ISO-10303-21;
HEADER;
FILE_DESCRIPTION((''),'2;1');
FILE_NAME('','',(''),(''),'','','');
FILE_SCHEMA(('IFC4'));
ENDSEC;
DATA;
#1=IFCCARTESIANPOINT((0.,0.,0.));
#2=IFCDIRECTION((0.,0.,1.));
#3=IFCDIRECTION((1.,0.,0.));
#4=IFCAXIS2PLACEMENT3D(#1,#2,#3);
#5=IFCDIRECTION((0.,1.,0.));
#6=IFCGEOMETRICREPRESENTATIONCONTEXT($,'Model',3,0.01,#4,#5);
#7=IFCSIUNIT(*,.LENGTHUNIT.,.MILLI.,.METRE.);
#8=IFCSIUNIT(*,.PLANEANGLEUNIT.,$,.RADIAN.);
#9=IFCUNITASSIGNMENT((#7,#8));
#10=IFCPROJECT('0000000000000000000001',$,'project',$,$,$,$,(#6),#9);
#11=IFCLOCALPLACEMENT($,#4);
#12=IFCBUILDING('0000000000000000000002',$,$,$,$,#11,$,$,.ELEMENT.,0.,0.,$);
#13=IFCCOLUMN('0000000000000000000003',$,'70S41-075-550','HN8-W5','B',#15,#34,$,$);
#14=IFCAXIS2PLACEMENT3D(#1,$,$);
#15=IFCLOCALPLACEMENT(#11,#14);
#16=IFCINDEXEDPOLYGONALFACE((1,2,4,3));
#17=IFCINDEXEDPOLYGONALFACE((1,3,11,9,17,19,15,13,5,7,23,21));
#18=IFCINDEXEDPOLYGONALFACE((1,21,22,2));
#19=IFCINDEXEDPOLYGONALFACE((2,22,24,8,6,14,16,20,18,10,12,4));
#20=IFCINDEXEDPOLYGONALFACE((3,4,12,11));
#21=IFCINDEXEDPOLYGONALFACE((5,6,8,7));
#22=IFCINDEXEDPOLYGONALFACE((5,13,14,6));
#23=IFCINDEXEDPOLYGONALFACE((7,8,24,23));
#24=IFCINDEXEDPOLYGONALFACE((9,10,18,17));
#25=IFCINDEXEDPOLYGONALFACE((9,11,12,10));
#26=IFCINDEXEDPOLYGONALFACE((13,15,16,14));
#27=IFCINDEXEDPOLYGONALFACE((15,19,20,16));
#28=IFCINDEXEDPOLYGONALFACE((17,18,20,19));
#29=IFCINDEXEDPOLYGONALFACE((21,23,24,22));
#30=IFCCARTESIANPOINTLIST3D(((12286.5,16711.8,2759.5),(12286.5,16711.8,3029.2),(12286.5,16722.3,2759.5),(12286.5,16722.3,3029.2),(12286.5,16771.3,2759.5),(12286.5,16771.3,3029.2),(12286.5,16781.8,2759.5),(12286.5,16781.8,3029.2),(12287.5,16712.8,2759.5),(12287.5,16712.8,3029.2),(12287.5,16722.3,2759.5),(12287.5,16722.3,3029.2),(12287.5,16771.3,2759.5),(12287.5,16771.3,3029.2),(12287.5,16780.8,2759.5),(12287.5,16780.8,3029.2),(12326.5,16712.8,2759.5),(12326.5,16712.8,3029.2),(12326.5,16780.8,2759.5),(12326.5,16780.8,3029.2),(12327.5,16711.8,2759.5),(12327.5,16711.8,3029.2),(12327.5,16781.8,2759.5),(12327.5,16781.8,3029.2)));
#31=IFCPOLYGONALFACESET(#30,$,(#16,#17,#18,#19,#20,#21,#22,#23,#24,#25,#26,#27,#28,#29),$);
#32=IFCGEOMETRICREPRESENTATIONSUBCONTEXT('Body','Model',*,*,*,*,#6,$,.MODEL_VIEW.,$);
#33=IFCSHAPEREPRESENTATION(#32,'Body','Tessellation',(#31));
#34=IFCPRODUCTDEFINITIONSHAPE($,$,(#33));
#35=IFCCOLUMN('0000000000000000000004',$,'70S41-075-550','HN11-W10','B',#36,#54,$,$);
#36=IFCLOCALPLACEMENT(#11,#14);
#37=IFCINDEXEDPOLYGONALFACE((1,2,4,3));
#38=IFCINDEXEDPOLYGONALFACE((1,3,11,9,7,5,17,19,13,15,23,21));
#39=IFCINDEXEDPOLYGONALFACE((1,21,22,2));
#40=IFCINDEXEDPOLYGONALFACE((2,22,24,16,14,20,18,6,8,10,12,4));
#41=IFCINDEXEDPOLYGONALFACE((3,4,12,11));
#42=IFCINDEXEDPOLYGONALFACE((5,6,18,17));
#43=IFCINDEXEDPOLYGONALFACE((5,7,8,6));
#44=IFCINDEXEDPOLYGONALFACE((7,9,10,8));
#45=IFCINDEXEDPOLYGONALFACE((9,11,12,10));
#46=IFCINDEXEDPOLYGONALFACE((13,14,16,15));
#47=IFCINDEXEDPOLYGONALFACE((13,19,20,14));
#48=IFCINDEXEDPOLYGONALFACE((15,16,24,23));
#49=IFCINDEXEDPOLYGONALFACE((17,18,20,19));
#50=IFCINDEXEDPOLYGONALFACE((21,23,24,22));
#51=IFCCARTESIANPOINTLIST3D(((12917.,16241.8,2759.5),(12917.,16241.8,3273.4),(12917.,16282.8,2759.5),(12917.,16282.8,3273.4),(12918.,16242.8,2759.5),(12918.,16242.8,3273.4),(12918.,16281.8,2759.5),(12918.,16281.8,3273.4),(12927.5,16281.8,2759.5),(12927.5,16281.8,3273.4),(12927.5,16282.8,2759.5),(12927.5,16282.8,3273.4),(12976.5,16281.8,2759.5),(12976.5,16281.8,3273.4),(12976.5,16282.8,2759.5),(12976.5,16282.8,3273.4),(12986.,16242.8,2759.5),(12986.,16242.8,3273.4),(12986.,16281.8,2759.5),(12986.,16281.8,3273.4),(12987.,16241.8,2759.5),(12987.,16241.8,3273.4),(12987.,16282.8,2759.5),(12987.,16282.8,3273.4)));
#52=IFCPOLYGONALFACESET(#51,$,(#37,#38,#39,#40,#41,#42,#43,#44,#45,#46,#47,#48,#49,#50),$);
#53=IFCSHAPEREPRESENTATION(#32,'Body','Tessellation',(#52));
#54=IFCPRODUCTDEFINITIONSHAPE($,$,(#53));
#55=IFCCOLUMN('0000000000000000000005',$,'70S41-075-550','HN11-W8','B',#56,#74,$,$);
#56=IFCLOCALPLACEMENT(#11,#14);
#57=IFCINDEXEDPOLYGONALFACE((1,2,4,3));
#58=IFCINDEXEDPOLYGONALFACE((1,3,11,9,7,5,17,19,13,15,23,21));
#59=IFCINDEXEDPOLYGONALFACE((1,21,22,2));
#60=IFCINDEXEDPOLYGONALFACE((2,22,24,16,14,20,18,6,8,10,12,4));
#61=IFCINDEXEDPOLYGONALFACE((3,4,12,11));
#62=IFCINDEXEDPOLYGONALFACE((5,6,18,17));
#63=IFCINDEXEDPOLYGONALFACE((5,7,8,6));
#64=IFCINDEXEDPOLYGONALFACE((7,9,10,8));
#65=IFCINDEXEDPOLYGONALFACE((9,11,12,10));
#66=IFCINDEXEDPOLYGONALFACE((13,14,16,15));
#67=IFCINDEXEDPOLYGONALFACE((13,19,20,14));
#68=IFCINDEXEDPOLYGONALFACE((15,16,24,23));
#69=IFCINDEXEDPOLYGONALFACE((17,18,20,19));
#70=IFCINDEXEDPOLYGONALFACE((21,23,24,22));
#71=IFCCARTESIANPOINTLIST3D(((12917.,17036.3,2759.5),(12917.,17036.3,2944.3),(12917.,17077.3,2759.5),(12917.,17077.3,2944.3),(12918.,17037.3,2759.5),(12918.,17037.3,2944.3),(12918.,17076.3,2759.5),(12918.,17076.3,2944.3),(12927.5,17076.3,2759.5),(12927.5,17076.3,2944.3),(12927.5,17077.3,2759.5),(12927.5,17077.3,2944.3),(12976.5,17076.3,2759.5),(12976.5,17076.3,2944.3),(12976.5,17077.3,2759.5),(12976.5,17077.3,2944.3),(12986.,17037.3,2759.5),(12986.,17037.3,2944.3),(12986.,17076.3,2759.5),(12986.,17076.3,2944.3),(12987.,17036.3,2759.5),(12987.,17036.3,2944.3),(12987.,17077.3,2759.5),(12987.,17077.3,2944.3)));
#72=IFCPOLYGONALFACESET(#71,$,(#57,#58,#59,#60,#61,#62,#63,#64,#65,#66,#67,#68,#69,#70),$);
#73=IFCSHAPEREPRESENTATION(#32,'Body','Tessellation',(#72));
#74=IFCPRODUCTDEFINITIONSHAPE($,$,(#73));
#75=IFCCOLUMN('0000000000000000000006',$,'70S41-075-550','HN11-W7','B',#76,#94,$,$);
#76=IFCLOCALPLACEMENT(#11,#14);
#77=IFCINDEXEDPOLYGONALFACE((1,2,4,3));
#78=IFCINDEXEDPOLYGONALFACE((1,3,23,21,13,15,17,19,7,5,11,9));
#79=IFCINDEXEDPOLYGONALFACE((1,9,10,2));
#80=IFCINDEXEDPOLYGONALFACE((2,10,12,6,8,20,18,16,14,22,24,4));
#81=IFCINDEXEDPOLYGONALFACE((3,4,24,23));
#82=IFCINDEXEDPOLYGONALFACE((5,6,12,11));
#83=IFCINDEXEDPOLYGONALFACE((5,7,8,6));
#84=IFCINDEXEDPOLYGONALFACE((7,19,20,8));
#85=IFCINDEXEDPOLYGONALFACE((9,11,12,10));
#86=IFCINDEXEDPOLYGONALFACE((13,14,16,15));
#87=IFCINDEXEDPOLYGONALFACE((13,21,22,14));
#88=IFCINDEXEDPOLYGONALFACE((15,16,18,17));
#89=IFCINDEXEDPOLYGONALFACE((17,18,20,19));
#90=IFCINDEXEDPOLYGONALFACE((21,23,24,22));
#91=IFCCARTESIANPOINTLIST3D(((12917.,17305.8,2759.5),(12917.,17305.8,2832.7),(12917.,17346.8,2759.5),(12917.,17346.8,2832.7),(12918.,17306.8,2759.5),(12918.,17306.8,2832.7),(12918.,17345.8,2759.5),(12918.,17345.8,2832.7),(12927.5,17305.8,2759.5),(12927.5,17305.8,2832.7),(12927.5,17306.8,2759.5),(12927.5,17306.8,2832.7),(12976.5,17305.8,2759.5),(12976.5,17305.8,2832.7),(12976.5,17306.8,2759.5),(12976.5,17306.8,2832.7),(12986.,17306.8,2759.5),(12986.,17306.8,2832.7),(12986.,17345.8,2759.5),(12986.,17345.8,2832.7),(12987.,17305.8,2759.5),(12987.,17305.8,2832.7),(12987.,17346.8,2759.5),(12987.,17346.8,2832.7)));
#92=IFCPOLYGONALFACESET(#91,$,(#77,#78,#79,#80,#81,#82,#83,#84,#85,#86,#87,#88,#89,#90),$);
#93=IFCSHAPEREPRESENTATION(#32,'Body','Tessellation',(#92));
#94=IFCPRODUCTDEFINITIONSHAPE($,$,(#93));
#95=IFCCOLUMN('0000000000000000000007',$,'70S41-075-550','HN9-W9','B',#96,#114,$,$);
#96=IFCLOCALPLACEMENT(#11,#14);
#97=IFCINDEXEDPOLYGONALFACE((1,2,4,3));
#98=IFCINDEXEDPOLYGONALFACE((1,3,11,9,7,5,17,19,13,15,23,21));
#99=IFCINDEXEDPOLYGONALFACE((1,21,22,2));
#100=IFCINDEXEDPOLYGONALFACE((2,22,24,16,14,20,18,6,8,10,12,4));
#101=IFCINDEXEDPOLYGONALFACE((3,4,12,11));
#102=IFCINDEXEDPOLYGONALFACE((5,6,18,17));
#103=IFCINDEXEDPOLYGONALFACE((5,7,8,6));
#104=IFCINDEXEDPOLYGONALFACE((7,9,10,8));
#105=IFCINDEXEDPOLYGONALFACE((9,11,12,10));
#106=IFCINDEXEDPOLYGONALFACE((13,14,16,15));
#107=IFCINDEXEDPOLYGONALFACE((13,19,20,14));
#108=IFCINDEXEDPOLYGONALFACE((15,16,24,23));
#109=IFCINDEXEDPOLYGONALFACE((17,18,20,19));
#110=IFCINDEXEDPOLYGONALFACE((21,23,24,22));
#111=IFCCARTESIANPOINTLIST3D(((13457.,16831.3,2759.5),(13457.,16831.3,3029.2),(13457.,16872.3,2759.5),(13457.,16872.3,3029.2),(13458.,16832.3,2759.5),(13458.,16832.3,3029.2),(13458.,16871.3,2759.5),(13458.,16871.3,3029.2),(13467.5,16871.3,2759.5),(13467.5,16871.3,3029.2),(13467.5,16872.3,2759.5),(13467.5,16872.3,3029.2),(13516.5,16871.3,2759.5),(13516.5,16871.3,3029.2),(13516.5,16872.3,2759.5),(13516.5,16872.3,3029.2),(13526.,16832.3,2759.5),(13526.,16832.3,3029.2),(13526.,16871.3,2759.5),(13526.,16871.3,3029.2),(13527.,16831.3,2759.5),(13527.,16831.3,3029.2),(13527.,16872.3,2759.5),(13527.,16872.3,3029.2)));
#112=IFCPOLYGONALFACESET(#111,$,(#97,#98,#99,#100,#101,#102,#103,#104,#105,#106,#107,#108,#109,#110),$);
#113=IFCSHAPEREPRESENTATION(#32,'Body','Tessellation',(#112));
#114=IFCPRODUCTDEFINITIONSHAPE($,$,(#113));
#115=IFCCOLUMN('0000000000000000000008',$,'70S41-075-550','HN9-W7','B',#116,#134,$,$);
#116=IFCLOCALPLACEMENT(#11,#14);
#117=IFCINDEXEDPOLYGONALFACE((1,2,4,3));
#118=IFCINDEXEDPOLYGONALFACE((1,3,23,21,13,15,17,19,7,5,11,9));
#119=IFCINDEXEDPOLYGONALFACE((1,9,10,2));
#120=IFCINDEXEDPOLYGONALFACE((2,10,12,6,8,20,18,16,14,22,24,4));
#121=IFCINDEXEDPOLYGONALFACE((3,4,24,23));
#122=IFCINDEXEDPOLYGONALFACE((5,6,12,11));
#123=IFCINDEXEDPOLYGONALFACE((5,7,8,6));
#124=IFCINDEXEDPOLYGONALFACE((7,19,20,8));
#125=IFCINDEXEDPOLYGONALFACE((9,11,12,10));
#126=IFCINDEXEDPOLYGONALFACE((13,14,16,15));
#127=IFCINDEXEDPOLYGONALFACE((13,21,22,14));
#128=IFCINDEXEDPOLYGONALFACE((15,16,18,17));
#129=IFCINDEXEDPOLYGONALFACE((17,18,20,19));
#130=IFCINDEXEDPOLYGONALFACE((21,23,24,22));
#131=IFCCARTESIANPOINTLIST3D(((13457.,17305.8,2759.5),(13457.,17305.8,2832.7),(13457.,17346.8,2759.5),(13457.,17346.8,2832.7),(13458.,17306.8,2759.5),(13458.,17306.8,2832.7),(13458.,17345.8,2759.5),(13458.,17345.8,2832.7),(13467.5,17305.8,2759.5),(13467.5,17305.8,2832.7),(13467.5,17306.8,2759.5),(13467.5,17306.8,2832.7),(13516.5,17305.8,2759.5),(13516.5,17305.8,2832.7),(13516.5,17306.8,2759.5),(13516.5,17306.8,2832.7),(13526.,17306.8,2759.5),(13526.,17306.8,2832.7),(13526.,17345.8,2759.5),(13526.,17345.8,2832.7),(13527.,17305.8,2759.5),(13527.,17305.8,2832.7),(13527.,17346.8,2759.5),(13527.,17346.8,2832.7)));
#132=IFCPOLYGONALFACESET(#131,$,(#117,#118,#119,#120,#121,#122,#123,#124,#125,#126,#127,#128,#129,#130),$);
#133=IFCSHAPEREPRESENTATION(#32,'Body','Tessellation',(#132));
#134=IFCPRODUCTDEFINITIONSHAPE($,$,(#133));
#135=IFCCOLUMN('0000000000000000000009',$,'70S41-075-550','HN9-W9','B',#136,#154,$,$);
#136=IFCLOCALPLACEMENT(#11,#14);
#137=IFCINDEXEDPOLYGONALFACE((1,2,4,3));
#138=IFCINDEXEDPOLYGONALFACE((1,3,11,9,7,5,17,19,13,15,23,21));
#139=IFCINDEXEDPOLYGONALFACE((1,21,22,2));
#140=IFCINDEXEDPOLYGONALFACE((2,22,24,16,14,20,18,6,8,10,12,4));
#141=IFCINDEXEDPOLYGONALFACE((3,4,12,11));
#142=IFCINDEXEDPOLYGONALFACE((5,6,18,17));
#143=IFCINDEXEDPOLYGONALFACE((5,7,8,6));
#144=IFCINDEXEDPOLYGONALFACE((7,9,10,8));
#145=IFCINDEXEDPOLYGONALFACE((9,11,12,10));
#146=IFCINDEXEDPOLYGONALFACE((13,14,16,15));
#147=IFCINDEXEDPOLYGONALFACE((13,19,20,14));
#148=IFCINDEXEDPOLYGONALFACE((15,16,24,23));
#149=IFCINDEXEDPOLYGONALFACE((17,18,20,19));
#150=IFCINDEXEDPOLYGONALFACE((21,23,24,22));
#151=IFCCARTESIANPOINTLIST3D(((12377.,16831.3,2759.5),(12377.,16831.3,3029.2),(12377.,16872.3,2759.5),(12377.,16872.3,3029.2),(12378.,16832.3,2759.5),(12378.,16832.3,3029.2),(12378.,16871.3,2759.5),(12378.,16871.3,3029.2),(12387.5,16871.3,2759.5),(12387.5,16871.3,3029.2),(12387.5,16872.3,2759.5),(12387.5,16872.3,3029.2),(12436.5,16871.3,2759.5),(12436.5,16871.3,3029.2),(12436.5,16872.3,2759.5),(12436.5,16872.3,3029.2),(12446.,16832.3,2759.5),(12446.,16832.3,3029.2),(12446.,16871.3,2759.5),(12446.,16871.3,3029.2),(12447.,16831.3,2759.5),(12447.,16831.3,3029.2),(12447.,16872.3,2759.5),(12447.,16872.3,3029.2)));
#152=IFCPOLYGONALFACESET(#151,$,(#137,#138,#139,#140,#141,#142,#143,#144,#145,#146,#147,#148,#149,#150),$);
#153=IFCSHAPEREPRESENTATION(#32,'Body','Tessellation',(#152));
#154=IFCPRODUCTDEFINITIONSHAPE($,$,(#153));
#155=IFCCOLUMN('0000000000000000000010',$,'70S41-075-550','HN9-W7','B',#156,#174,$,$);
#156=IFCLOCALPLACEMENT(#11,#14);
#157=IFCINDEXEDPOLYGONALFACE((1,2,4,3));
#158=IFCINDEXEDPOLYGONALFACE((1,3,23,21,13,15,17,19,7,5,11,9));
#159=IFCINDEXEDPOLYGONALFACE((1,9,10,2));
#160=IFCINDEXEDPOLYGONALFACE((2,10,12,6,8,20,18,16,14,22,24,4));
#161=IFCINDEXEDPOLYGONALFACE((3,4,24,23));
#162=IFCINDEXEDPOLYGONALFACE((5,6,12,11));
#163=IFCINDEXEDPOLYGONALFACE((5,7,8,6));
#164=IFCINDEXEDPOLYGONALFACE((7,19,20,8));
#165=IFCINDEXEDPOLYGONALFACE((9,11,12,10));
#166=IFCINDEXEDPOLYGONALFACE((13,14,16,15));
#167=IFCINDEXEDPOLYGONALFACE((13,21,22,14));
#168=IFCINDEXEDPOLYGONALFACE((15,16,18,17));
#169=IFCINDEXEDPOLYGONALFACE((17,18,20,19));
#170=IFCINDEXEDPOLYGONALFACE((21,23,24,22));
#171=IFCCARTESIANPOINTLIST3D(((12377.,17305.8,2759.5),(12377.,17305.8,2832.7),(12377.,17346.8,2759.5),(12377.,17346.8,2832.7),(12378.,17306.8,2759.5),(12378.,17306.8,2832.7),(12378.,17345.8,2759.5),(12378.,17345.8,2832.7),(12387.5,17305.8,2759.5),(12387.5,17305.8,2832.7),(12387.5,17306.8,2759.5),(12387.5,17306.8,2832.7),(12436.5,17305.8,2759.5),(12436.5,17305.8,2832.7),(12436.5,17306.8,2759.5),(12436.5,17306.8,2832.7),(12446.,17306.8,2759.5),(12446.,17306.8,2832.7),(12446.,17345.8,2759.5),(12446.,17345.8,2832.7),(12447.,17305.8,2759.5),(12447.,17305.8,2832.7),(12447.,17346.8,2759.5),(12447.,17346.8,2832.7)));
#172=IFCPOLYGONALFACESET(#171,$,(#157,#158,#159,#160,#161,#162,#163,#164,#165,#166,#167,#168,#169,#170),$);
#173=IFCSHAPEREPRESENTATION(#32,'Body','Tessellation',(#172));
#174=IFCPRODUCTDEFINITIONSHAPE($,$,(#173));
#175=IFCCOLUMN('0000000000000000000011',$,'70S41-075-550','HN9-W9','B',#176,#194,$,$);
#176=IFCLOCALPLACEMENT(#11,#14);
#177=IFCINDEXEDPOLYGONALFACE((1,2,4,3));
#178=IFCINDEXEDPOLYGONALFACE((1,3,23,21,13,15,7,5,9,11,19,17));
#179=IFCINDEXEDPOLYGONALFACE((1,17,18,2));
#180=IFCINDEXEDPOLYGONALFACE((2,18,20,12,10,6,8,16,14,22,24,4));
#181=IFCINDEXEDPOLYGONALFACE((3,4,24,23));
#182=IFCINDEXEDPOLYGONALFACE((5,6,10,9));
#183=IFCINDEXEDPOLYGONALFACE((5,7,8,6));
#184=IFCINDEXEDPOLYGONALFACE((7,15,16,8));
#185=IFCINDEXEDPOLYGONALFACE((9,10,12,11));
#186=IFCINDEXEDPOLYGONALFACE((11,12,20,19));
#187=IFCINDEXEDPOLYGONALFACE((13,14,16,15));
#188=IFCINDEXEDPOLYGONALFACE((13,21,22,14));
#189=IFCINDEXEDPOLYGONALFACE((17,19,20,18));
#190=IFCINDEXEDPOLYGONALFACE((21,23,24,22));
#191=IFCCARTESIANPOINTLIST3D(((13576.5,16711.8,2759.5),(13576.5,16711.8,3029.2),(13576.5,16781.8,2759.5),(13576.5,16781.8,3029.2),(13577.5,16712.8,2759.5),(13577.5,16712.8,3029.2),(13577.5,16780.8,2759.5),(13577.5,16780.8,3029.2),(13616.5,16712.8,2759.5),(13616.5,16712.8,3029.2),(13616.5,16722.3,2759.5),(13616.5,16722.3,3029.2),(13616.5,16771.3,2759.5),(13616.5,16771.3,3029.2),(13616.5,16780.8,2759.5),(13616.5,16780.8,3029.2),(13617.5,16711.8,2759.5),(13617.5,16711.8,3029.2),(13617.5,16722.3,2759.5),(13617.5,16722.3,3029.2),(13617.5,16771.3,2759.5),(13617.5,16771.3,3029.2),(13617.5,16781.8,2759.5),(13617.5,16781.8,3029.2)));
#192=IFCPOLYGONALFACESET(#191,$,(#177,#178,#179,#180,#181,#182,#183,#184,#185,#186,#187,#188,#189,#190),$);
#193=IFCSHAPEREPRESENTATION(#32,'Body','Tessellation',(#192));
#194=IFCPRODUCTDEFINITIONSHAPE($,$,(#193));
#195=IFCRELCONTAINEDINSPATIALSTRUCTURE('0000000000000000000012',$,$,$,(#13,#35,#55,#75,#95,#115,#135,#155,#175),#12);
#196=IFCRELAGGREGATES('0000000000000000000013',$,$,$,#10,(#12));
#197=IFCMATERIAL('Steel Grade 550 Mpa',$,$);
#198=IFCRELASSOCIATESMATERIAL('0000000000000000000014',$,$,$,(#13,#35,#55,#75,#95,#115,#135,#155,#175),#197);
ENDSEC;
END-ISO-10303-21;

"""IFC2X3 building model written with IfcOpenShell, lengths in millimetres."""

from ifc_helpers import new_model, si_unit, direction, frame, origin, origin_with_axes, origin_2d_with_axis, place, context, subcontext, project, spatial, c_section, extrude, source, transform, mapped, material, element, save


model = new_model("IFC2X3")

# Units and contexts
model_context = context("Model", 3, precision=0.01, world=origin_with_axes(), true_north=direction((0.0, 1.0, 0.0)))
body_context = subcontext(model_context, "Body", "Model", "MODEL_VIEW")
ifc_project = project(units=[si_unit("LENGTHUNIT", "METRE", prefix="MILLI"), si_unit("PLANEANGLEUNIT", "RADIAN")], contexts=[model_context])

# Building
building_placement = place(None, origin_with_axes())
building = spatial("IfcBuilding", under=ifc_project, at=building_placement, CompositionType="ELEMENT", ElevationOfRefHeight=0.0, ElevationOfTerrain=0.0)

# Columns
ifc_material = material(Name="Steel Grade 550 Mpa")
shared_shape_1 = source(origin(), body_context, "Body", "SweptSolid", [
    extrude(c_section(Depth=70.0, Width=41.0, WallThickness=1.0, Girth=10.5, at=origin_2d_with_axis()), origin_with_axes(), (0.0, 0.0, 1.0), 269.7),
])
column_1_placement = place(None, frame((12307.0, 16746.8, 2759.5), z_axis=(0.0, 0.0, 1.0), x_axis=(-1.0, 0.0, 0.0)))
element("IfcColumn", 1, at=column_1_placement, inside=building, material=ifc_material, Name="70S41-075-550", Description="HN8-W5", ObjectType="B", context=body_context, shape_type="MappedRepresentation", body=[
    mapped(shared_shape_1, transform((0.0, 0.0, 0.0), scale=1.0)),
])
shared_shape_2 = source(origin(), body_context, "Body", "SweptSolid", [
    extrude(c_section(Depth=70.0, Width=41.0, WallThickness=1.0, Girth=10.5, at=origin_2d_with_axis()), origin_with_axes(), (0.0, 0.0, 1.0), 513.9),
])
column_2_placement = place(None, frame((12952.0, 16262.3, 2759.5), z_axis=(0.0, 0.0, 1.0), x_axis=(0.0, 1.0, 0.0)))
element("IfcColumn", 2, at=column_2_placement, inside=building, material=ifc_material, Name="70S41-075-550", Description="HN11-W10", ObjectType="B", context=body_context, shape_type="MappedRepresentation", body=[
    mapped(shared_shape_2, transform((0.0, 0.0, 0.0), scale=1.0)),
])
shared_shape_3 = source(origin(), body_context, "Body", "SweptSolid", [
    extrude(c_section(Depth=70.0, Width=41.0, WallThickness=1.0, Girth=10.5, at=origin_2d_with_axis()), origin_with_axes(), (0.0, 0.0, 1.0), 184.8),
])
column_3_placement = place(None, frame((12952.0, 17056.8, 2759.5), z_axis=(0.0, 0.0, 1.0), x_axis=(0.0, 1.0, 0.0)))
element("IfcColumn", 3, at=column_3_placement, inside=building, material=ifc_material, Name="70S41-075-550", Description="HN11-W8", ObjectType="B", context=body_context, shape_type="MappedRepresentation", body=[
    mapped(shared_shape_3, transform((0.0, 0.0, 0.0), scale=1.0)),
])
shared_shape_4 = source(origin(), body_context, "Body", "SweptSolid", [
    extrude(c_section(Depth=70.0, Width=41.0, WallThickness=1.0, Girth=10.5, at=origin_2d_with_axis()), origin_with_axes(), (0.0, 0.0, 1.0), 73.2),
])
column_4_placement = place(None, frame((12952.0, 17326.3, 2832.7), z_axis=(0.0, 0.0, -1.0), x_axis=(0.0, -1.0, 0.0)))
element("IfcColumn", 4, at=column_4_placement, inside=building, material=ifc_material, Name="70S41-075-550", Description="HN11-W7", ObjectType="B", context=body_context, shape_type="MappedRepresentation", body=[
    mapped(shared_shape_4, transform((0.0, 0.0, 0.0), scale=1.0)),
])
shared_shape_5 = source(origin(), body_context, "Body", "SweptSolid", [
    extrude(c_section(Depth=70.0, Width=41.0, WallThickness=1.0, Girth=10.5, at=origin_2d_with_axis()), origin_with_axes(), (0.0, 0.0, 1.0), 269.7),
])
column_5_placement = place(None, frame((13492.0, 16851.8, 2759.5), z_axis=(0.0, 0.0, 1.0), x_axis=(0.0, 1.0, 0.0)))
element("IfcColumn", 5, at=column_5_placement, inside=building, material=ifc_material, Name="70S41-075-550", Description="HN9-W9", ObjectType="B", context=body_context, shape_type="MappedRepresentation", body=[
    mapped(shared_shape_5, transform((0.0, 0.0, 0.0), scale=1.0)),
])
shared_shape_6 = source(origin(), body_context, "Body", "SweptSolid", [
    extrude(c_section(Depth=70.0, Width=41.0, WallThickness=1.0, Girth=10.5, at=origin_2d_with_axis()), origin_with_axes(), (0.0, 0.0, 1.0), 73.2),
])
column_6_placement = place(None, frame((13492.0, 17326.3, 2832.7), z_axis=(0.0, 0.0, -1.0), x_axis=(0.0, -1.0, 0.0)))
element("IfcColumn", 6, at=column_6_placement, inside=building, material=ifc_material, Name="70S41-075-550", Description="HN9-W7", ObjectType="B", context=body_context, shape_type="MappedRepresentation", body=[
    mapped(shared_shape_6, transform((0.0, 0.0, 0.0), scale=1.0)),
])
shared_shape_7 = source(origin(), body_context, "Body", "SweptSolid", [
    extrude(c_section(Depth=70.0, Width=41.0, WallThickness=1.0, Girth=10.5, at=origin_2d_with_axis()), origin_with_axes(), (0.0, 0.0, 1.0), 269.7),
])
column_7_placement = place(None, frame((12412.0, 16851.8, 2759.5), z_axis=(0.0, 0.0, 1.0), x_axis=(0.0, 1.0, 0.0)))
element("IfcColumn", 7, at=column_7_placement, inside=building, material=ifc_material, Name="70S41-075-550", Description="HN9-W9", ObjectType="B", context=body_context, shape_type="MappedRepresentation", body=[
    mapped(shared_shape_7, transform((0.0, 0.0, 0.0), scale=1.0)),
])
shared_shape_8 = source(origin(), body_context, "Body", "SweptSolid", [
    extrude(c_section(Depth=70.0, Width=41.0, WallThickness=1.0, Girth=10.5, at=origin_2d_with_axis()), origin_with_axes(), (0.0, 0.0, 1.0), 73.2),
])
column_8_placement = place(None, frame((12412.0, 17326.3, 2832.7), z_axis=(0.0, 0.0, -1.0), x_axis=(0.0, -1.0, 0.0)))
element("IfcColumn", 8, at=column_8_placement, inside=building, material=ifc_material, Name="70S41-075-550", Description="HN9-W7", ObjectType="B", context=body_context, shape_type="MappedRepresentation", body=[
    mapped(shared_shape_8, transform((0.0, 0.0, 0.0), scale=1.0)),
])
shared_shape_9 = source(origin(), body_context, "Body", "SweptSolid", [
    extrude(c_section(Depth=70.0, Width=41.0, WallThickness=1.0, Girth=10.5, at=origin_2d_with_axis()), origin_with_axes(), (0.0, 0.0, 1.0), 269.7),
])
column_9_placement = place(None, frame((13597.0, 16746.8, 2759.5), z_axis=(0.0, 0.0, 1.0), x_axis=(1.0, 0.0, 0.0)))
element("IfcColumn", 9, at=column_9_placement, inside=building, material=ifc_material, Name="70S41-075-550", Description="HN9-W9", ObjectType="B", context=body_context, shape_type="MappedRepresentation", body=[
    mapped(shared_shape_9, transform((0.0, 0.0, 0.0), scale=1.0)),
])

save(model, "model.ifc")
